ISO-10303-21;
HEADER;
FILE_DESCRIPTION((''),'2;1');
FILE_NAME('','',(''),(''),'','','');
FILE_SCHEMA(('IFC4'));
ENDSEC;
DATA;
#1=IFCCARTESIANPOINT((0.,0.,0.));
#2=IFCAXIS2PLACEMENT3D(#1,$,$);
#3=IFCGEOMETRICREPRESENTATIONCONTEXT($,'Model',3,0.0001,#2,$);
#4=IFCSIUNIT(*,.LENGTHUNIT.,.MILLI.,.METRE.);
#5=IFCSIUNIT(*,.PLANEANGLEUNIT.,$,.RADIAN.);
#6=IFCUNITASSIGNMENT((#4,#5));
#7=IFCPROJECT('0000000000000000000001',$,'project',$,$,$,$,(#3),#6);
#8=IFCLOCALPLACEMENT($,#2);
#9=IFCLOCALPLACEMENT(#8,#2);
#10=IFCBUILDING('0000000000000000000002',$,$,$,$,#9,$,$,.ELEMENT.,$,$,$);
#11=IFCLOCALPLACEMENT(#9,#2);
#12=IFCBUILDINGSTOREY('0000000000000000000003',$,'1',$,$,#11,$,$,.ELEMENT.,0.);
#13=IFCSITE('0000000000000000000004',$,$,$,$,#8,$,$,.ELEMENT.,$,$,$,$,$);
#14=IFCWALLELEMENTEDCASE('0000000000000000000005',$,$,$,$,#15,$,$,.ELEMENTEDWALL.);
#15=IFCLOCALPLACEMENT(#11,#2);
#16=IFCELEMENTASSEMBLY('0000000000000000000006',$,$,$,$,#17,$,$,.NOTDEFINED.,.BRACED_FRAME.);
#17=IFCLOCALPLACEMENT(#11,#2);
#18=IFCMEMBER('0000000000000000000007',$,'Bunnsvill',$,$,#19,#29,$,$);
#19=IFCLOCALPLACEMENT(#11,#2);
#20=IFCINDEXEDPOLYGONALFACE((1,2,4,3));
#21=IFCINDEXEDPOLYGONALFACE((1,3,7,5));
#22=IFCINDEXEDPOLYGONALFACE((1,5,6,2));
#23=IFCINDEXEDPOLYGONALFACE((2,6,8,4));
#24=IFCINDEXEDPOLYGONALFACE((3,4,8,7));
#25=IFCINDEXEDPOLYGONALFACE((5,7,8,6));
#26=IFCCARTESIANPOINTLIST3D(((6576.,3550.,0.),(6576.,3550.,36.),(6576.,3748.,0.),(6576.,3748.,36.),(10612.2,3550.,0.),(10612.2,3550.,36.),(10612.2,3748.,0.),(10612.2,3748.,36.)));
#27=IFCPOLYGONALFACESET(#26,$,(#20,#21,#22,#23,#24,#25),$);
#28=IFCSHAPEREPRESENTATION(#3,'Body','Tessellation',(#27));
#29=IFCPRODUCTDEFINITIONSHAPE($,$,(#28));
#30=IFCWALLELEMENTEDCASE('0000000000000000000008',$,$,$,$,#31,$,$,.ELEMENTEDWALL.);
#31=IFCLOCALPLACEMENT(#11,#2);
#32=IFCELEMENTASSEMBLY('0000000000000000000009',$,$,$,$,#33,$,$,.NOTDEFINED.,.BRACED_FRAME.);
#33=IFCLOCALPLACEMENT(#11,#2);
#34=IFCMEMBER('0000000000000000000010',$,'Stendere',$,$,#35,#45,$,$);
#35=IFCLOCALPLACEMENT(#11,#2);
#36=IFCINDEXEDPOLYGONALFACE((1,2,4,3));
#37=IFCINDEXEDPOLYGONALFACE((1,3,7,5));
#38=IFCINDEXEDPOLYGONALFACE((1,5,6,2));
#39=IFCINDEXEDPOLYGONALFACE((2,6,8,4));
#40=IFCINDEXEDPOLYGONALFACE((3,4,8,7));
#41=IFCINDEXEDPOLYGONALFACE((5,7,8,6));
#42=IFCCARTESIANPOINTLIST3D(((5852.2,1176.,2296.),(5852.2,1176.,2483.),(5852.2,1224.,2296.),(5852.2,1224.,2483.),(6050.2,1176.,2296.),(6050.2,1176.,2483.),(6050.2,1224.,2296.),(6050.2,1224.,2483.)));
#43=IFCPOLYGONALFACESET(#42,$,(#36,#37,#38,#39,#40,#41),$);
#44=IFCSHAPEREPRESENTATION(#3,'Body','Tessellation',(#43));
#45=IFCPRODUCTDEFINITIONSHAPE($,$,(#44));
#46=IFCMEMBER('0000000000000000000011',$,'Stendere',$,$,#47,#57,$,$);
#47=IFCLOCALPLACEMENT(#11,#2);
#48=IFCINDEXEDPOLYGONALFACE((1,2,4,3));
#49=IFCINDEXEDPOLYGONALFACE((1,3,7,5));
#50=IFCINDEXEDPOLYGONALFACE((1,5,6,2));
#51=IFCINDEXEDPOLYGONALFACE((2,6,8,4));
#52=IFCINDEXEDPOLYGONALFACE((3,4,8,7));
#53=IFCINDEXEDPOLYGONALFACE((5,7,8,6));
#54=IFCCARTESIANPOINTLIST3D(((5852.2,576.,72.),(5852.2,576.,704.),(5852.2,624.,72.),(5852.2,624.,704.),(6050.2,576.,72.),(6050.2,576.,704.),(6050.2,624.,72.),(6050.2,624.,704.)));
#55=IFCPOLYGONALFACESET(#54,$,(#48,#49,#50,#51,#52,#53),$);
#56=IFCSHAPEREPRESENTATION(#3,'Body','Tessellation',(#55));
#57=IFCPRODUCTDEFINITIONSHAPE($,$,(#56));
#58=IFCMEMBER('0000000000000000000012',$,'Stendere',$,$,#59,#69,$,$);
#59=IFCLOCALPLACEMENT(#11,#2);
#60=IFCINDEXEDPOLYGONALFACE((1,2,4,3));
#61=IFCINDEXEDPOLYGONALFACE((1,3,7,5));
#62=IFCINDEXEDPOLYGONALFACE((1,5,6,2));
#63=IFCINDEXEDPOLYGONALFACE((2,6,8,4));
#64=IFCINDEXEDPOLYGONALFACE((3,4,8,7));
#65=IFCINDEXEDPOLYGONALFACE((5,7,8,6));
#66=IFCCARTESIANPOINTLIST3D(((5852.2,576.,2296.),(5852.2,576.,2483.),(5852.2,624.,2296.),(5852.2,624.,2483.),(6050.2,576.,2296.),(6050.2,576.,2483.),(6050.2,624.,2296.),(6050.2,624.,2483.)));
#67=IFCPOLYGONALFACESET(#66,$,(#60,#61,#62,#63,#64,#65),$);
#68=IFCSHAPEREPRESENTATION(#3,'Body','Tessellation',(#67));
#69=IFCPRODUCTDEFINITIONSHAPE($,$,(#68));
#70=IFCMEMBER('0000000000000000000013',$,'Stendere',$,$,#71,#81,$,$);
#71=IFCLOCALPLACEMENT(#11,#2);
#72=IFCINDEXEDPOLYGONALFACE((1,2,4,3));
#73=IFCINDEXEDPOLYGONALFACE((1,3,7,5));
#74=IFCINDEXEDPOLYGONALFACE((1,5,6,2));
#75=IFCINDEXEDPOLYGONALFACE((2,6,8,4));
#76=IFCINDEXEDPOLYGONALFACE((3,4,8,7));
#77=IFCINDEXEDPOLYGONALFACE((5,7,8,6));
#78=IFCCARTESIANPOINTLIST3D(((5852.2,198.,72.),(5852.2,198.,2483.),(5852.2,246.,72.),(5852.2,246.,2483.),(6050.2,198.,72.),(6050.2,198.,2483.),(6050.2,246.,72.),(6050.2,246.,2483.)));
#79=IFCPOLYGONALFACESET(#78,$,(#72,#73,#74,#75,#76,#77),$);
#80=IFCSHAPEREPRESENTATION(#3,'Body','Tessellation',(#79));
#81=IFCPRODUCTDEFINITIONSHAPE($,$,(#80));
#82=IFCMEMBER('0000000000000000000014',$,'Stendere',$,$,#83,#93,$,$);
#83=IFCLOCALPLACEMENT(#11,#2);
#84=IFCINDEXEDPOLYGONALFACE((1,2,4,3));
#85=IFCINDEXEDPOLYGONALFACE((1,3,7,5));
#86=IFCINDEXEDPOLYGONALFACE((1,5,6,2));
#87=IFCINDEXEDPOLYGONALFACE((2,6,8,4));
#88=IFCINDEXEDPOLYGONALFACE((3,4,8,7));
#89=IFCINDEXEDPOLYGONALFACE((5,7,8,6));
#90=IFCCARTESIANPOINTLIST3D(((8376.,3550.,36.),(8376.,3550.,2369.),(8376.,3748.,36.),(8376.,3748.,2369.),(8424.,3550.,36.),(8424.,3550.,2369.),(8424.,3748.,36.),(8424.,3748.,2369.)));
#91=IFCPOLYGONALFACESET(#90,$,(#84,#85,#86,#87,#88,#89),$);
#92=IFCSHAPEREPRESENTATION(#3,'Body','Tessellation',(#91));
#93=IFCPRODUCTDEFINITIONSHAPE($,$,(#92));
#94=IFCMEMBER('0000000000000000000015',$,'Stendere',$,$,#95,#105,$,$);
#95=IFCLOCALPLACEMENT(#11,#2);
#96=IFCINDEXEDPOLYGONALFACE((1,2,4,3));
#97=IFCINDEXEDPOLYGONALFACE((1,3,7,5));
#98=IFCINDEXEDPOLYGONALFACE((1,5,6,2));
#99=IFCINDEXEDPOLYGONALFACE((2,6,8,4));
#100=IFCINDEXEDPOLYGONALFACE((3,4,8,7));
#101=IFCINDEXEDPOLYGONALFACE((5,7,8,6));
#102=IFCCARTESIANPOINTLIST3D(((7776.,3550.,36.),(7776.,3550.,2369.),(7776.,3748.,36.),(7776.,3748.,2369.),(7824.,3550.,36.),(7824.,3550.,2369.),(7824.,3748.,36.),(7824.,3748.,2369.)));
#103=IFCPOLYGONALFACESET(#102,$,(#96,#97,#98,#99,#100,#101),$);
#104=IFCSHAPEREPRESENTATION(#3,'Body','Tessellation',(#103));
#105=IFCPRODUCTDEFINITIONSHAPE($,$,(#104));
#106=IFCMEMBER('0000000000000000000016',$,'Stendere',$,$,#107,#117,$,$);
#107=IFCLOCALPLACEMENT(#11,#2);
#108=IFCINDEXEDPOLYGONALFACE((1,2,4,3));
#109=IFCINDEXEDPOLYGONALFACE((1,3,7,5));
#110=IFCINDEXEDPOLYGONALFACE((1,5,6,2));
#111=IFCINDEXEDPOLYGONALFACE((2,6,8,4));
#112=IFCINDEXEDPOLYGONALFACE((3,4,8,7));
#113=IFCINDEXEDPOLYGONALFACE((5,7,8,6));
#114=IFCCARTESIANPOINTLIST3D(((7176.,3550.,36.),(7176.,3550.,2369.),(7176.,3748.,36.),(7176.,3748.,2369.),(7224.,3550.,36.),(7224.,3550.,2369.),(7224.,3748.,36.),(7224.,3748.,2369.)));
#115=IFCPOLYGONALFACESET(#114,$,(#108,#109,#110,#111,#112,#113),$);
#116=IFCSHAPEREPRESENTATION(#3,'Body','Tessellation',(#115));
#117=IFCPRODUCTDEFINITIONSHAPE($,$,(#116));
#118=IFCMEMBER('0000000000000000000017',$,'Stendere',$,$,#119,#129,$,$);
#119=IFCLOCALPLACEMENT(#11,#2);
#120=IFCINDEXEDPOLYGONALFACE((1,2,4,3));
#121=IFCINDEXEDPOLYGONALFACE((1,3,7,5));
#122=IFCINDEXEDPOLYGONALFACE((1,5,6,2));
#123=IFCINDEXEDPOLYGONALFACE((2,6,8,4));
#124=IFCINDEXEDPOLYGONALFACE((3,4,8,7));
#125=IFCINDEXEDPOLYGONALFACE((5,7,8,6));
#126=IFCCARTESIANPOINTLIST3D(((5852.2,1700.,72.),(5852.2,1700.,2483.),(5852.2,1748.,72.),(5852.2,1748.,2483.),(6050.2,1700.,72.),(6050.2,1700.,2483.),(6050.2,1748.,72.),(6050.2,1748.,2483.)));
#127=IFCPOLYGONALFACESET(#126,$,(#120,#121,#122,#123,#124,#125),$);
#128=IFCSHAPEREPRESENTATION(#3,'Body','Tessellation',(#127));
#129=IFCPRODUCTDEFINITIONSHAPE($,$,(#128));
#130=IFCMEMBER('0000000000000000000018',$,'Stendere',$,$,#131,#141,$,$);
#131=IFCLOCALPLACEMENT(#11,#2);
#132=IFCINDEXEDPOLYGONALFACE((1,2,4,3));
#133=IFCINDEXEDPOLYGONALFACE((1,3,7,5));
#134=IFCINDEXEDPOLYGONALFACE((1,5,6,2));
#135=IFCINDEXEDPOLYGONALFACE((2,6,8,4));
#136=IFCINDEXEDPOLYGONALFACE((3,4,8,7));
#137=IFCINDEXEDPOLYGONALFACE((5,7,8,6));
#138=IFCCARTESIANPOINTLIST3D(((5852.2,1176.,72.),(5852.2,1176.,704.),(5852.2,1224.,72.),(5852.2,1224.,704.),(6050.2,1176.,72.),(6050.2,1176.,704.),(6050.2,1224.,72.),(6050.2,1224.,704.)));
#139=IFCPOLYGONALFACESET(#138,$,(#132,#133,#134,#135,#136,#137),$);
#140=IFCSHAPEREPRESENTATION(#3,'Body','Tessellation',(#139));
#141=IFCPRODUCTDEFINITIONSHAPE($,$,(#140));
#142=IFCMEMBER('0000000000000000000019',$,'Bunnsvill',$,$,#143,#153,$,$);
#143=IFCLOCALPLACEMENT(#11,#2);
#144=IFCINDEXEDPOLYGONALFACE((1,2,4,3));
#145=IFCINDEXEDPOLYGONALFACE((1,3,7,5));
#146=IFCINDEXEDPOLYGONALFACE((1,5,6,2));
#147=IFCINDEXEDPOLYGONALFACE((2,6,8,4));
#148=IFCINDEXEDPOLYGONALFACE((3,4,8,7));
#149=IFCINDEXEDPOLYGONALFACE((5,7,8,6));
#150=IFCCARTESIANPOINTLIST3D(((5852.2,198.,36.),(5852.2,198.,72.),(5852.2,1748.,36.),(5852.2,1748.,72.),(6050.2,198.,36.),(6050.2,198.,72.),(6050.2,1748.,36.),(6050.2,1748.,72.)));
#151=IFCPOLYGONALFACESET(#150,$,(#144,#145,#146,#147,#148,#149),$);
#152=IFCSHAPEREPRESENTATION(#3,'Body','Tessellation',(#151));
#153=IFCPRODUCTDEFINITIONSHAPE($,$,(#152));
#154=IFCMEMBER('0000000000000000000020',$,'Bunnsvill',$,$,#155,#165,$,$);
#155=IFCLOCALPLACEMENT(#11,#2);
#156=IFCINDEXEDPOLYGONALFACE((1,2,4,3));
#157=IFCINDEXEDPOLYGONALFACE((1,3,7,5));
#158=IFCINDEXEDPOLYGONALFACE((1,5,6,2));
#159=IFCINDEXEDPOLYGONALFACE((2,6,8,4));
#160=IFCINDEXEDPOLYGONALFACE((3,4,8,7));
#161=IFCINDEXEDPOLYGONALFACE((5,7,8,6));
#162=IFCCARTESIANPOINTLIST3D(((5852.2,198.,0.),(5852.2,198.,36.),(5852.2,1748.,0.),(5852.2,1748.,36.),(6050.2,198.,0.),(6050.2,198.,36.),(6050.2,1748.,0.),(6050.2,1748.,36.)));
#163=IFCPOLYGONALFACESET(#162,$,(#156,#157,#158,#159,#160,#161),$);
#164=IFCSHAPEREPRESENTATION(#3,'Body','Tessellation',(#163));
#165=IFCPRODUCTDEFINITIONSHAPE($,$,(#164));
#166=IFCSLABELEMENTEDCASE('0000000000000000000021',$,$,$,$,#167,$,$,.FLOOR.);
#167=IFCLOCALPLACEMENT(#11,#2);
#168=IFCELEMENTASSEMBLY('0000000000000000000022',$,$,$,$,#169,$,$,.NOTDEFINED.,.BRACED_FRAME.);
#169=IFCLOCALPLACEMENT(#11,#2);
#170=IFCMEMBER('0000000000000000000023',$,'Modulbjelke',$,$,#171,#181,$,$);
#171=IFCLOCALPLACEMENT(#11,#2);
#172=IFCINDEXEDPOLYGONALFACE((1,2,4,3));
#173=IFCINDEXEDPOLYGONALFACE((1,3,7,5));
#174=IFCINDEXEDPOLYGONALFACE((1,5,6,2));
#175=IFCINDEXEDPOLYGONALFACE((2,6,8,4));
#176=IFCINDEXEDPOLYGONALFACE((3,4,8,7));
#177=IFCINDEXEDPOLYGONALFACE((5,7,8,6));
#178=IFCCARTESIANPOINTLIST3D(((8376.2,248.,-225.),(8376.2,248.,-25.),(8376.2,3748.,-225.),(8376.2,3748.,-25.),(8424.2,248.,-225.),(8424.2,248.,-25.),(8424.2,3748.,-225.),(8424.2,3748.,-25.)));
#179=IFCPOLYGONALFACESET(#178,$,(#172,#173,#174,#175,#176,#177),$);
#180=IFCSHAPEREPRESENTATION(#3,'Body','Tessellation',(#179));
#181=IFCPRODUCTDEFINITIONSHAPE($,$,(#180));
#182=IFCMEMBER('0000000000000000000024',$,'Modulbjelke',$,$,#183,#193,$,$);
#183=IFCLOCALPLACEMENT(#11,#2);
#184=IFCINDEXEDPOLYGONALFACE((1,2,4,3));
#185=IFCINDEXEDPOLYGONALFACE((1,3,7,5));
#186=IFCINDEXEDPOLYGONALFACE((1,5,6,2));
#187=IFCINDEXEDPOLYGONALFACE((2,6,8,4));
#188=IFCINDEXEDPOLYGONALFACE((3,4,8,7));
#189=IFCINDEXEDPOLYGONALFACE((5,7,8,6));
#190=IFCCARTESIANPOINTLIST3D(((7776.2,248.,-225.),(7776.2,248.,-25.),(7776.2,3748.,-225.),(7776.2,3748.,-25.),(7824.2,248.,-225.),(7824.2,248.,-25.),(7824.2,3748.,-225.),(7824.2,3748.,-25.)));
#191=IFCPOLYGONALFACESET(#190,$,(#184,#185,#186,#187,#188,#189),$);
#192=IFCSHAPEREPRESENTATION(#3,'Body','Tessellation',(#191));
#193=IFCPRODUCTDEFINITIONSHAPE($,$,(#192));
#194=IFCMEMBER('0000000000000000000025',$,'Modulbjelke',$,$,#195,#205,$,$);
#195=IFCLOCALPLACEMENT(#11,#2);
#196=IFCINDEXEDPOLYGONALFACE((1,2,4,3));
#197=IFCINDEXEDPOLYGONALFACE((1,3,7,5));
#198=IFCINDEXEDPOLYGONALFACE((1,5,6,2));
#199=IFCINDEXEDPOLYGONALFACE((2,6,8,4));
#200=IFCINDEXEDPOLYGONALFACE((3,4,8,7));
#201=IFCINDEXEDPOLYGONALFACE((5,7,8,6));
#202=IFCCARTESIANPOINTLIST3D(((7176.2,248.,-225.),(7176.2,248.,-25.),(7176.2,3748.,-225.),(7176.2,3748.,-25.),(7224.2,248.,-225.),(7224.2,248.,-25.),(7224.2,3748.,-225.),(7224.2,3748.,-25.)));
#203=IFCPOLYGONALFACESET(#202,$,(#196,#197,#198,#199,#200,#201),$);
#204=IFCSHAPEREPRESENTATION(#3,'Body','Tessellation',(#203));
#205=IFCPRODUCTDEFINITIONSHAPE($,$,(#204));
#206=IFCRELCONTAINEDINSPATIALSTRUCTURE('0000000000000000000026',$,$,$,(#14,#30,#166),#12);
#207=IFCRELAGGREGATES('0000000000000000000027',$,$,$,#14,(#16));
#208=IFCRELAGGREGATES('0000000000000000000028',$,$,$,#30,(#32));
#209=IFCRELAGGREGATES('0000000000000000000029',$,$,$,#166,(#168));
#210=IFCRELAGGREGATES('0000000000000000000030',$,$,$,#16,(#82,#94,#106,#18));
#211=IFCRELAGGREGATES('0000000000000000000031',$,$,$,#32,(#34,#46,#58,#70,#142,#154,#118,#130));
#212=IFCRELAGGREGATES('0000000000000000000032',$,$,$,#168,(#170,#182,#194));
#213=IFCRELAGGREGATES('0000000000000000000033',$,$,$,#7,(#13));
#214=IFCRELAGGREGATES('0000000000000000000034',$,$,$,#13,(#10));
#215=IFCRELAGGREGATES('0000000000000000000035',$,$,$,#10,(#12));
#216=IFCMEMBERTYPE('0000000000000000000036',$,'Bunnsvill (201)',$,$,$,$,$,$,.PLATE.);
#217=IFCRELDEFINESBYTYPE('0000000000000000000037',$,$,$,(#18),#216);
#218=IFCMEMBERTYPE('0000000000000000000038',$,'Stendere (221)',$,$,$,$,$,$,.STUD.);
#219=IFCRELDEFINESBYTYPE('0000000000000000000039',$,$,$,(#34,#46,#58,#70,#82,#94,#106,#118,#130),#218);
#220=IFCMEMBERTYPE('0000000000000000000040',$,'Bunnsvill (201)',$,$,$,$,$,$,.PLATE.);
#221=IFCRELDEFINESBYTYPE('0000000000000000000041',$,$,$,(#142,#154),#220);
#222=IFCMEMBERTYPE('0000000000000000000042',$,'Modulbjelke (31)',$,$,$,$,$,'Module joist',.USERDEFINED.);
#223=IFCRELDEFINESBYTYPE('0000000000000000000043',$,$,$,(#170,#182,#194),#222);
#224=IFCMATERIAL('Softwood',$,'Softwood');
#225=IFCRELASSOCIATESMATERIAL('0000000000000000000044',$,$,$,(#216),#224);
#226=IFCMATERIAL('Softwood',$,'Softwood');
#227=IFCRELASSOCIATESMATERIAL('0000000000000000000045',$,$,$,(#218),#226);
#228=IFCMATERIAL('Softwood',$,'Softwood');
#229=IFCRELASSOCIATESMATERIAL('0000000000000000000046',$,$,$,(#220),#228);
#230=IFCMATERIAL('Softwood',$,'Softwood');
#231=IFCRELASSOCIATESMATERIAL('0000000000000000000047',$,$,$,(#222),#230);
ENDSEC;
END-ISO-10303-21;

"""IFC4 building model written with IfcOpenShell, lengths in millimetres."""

from ifc_helpers import new_model, si_unit, frame, origin, place, context, project, spatial, rectangle, extrude, material, material_profile, profile_set, type_object, element, aggregate, save


model = new_model("IFC4")

# Units and contexts
model_context = context("Model", 3, precision=0.0001, world=origin())
ifc_project = project(units=[si_unit("LENGTHUNIT", "METRE", prefix="MILLI"), si_unit("PLANEANGLEUNIT", "RADIAN")], contexts=[model_context])

# Site, building, storey
site_placement = place(None, origin())
site = spatial("IfcSite", under=ifc_project, at=site_placement, CompositionType="ELEMENT")
building_placement = place(site_placement, origin())
building = spatial("IfcBuilding", under=site, at=building_placement, CompositionType="ELEMENT")
storey_placement = place(building_placement, origin())
storey = spatial("IfcBuildingStorey", under=building, at=storey_placement, Name="1", CompositionType="ELEMENT", Elevation=0.0)

# Wall, element assembly, member
wall_1_placement = place(storey_placement, frame((6576.0, 3748.0, 0.0), z_axis=(0.0, -1.0, 0.0)))
wall_1 = element("IfcWallElementedCase", 1, at=wall_1_placement, inside=storey, PredefinedType="ELEMENTEDWALL")
assembly_1_placement = place(wall_1_placement, origin())
assembly_1 = element("IfcElementAssembly", 2, at=assembly_1_placement, AssemblyPlace="NOTDEFINED", PredefinedType="BRACED_FRAME")
aggregate(wall_1, [assembly_1])
ifc_material_1 = material(Name="Softwood", Category="Softwood")
ifc_material_profile_1 = material_profile(ifc_material_1, rectangle(XDim=36.0, YDim=198.0), Name="Bunnsvill (201)")
ifc_profile_set_1 = profile_set([ifc_material_profile_1])
member_type_1 = type_object("IfcMemberType", Name="Bunnsvill (201)", PredefinedType="PLATE", material=ifc_profile_set_1)
member_1_placement = place(assembly_1_placement, frame((0.0, 18.0, 0.0), z_axis=(1.0, 0.0, 0.0), x_axis=(0.0, 1.0, 0.0)))
member_1 = element("IfcMember", 3, at=member_1_placement, type_object=member_type_1, Name="Bunnsvill", context=model_context, shape_type="SweptSolid", body=[
    extrude(rectangle(XDim=36.0, YDim=198.0), frame((0.0, 99.0, 0.0)), (0.0, 0.0, 1.0), 4036.2),
])

# Wall, element assembly, members
wall_2_placement = place(storey_placement, frame((6050.2, 1748.0, 0.0), z_axis=(-1.0, 0.0, 0.0), x_axis=(0.0, -1.0, 0.0)))
wall_2 = element("IfcWallElementedCase", 4, at=wall_2_placement, inside=storey, PredefinedType="ELEMENTEDWALL")
assembly_2_placement = place(wall_2_placement, origin())
assembly_2 = element("IfcElementAssembly", 5, at=assembly_2_placement, AssemblyPlace="NOTDEFINED", PredefinedType="BRACED_FRAME")
aggregate(wall_2, [assembly_2])
ifc_material_2 = material(Name="Softwood", Category="Softwood")
ifc_material_profile_2 = material_profile(ifc_material_2, rectangle(XDim=48.0, YDim=198.0), Name="Stendere (221)")
ifc_profile_set_2 = profile_set([ifc_material_profile_2])
member_type_2 = type_object("IfcMemberType", Name="Stendere (221)", PredefinedType="STUD", material=ifc_profile_set_2)
member_2_placement = place(assembly_2_placement, frame((548.0, 2296.0, 0.0), z_axis=(0.0, 1.0, 0.0), x_axis=(-1.0, 0.0, 0.0)))
member_2 = element("IfcMember", 6, at=member_2_placement, type_object=member_type_2, Name="Stendere", context=model_context, shape_type="SweptSolid", body=[
    extrude(rectangle(XDim=48.0, YDim=198.0), frame((0.0, 99.0, 0.0)), (0.0, 0.0, 1.0), 187.0),
])
member_3_placement = place(assembly_2_placement, frame((1148.0, 72.0, 0.0), z_axis=(0.0, 1.0, 0.0), x_axis=(-1.0, 0.0, 0.0)))
member_3 = element("IfcMember", 7, at=member_3_placement, type_object=member_type_2, Name="Stendere", context=model_context, shape_type="SweptSolid", body=[
    extrude(rectangle(XDim=48.0, YDim=198.0), frame((0.0, 99.0, 0.0)), (0.0, 0.0, 1.0), 632.0),
])
member_4_placement = place(assembly_2_placement, frame((1148.0, 2296.0, 0.0), z_axis=(0.0, 1.0, 0.0), x_axis=(-1.0, 0.0, 0.0)))
member_4 = element("IfcMember", 8, at=member_4_placement, type_object=member_type_2, Name="Stendere", context=model_context, shape_type="SweptSolid", body=[
    extrude(rectangle(XDim=48.0, YDim=198.0), frame((0.0, 99.0, 0.0)), (0.0, 0.0, 1.0), 187.0),
])
member_5_placement = place(assembly_2_placement, frame((1526.0, 72.0, 0.0), z_axis=(0.0, 1.0, 0.0), x_axis=(-1.0, 0.0, 0.0)))
member_5 = element("IfcMember", 9, at=member_5_placement, type_object=member_type_2, Name="Stendere", context=model_context, shape_type="SweptSolid", body=[
    extrude(rectangle(XDim=48.0, YDim=198.0), frame((0.0, 99.0, 0.0)), (0.0, 0.0, 1.0), 2411.0),
])

# Members
member_6_placement = place(assembly_1_placement, frame((1824.0, 36.0, 0.0), z_axis=(0.0, 1.0, 0.0), x_axis=(-1.0, 0.0, 0.0)))
member_6 = element("IfcMember", 10, at=member_6_placement, type_object=member_type_2, Name="Stendere", context=model_context, shape_type="SweptSolid", body=[
    extrude(rectangle(XDim=48.0, YDim=198.0), frame((0.0, 99.0, 0.0)), (0.0, 0.0, 1.0), 2333.0),
])
member_7_placement = place(assembly_1_placement, frame((1224.0, 36.0, 0.0), z_axis=(0.0, 1.0, 0.0), x_axis=(-1.0, 0.0, 0.0)))
member_7 = element("IfcMember", 11, at=member_7_placement, type_object=member_type_2, Name="Stendere", context=model_context, shape_type="SweptSolid", body=[
    extrude(rectangle(XDim=48.0, YDim=198.0), frame((0.0, 99.0, 0.0)), (0.0, 0.0, 1.0), 2333.0),
])
member_8_placement = place(assembly_1_placement, frame((624.0, 36.0, 0.0), z_axis=(0.0, 1.0, 0.0), x_axis=(-1.0, 0.0, 0.0)))
member_8 = element("IfcMember", 12, at=member_8_placement, type_object=member_type_2, Name="Stendere", context=model_context, shape_type="SweptSolid", body=[
    extrude(rectangle(XDim=48.0, YDim=198.0), frame((0.0, 99.0, 0.0)), (0.0, 0.0, 1.0), 2333.0),
])
member_9_placement = place(assembly_2_placement, frame((24.0, 72.0, 0.0), z_axis=(0.0, 1.0, 0.0), x_axis=(-1.0, 0.0, 0.0)))
member_9 = element("IfcMember", 13, at=member_9_placement, type_object=member_type_2, Name="Stendere", context=model_context, shape_type="SweptSolid", body=[
    extrude(rectangle(XDim=48.0, YDim=198.0), frame((0.0, 99.0, 0.0)), (0.0, 0.0, 1.0), 2411.0),
])
member_10_placement = place(assembly_2_placement, frame((548.0, 72.0, 0.0), z_axis=(0.0, 1.0, 0.0), x_axis=(-1.0, 0.0, 0.0)))
member_10 = element("IfcMember", 14, at=member_10_placement, type_object=member_type_2, Name="Stendere", context=model_context, shape_type="SweptSolid", body=[
    extrude(rectangle(XDim=48.0, YDim=198.0), frame((0.0, 99.0, 0.0)), (0.0, 0.0, 1.0), 632.0),
])
ifc_material_3 = material(Name="Softwood", Category="Softwood")
ifc_material_profile_3 = material_profile(ifc_material_3, rectangle(XDim=36.0, YDim=198.0), Name="Bunnsvill (201)")
ifc_profile_set_3 = profile_set([ifc_material_profile_3])
member_type_3 = type_object("IfcMemberType", Name="Bunnsvill (201)", PredefinedType="PLATE", material=ifc_profile_set_3)
member_11_placement = place(assembly_2_placement, frame((0.0, 54.0, 0.0), z_axis=(1.0, 0.0, 0.0), x_axis=(0.0, 1.0, 0.0)))
member_11 = element("IfcMember", 15, at=member_11_placement, type_object=member_type_3, Name="Bunnsvill", context=model_context, shape_type="SweptSolid", body=[
    extrude(rectangle(XDim=36.0, YDim=198.0), frame((0.0, 99.0, 0.0)), (0.0, 0.0, 1.0), 1550.0),
])
member_12_placement = place(assembly_2_placement, frame((0.0, 18.0, 0.0), z_axis=(1.0, 0.0, 0.0), x_axis=(0.0, 1.0, 0.0)))
member_12 = element("IfcMember", 16, at=member_12_placement, type_object=member_type_3, Name="Bunnsvill", context=model_context, shape_type="SweptSolid", body=[
    extrude(rectangle(XDim=36.0, YDim=198.0), frame((0.0, 99.0, 0.0)), (0.0, 0.0, 1.0), 1550.0),
])

# Slab, element assembly, members
slab_placement = place(storey_placement, origin())
slab = element("IfcSlabElementedCase", 17, at=slab_placement, inside=storey, PredefinedType="FLOOR")
assembly_3_placement = place(slab_placement, frame((0.0, 0.0, -225.0)))
assembly_3 = element("IfcElementAssembly", 18, at=assembly_3_placement, AssemblyPlace="NOTDEFINED", PredefinedType="BRACED_FRAME")
aggregate(slab, [assembly_3])
ifc_material_4 = material(Name="Softwood", Category="Softwood")
ifc_material_profile_4 = material_profile(ifc_material_4, rectangle(XDim=48.0, YDim=200.0), Name="Modulbjelke (31)")
ifc_profile_set_4 = profile_set([ifc_material_profile_4])
member_type_4 = type_object("IfcMemberType", Name="Modulbjelke (31)", ElementType="Module joist", PredefinedType="USERDEFINED", material=ifc_profile_set_4)
member_13_placement = place(assembly_3_placement, frame((8400.2, 248.0, 0.0), z_axis=(0.0, 1.0, 0.0), x_axis=(-1.0, 0.0, 0.0)))
member_13 = element("IfcMember", 19, at=member_13_placement, type_object=member_type_4, Name="Modulbjelke", context=model_context, shape_type="SweptSolid", body=[
    extrude(rectangle(XDim=48.0, YDim=200.0), frame((0.0, 100.0, 0.0)), (0.0, 0.0, 1.0), 3500.0),
])
member_14_placement = place(assembly_3_placement, frame((7800.2, 248.0, 0.0), z_axis=(0.0, 1.0, 0.0), x_axis=(-1.0, 0.0, 0.0)))
member_14 = element("IfcMember", 20, at=member_14_placement, type_object=member_type_4, Name="Modulbjelke", context=model_context, shape_type="SweptSolid", body=[
    extrude(rectangle(XDim=48.0, YDim=200.0), frame((0.0, 100.0, 0.0)), (0.0, 0.0, 1.0), 3500.0),
])
member_15_placement = place(assembly_3_placement, frame((7200.2, 248.0, 0.0), z_axis=(0.0, 1.0, 0.0), x_axis=(-1.0, 0.0, 0.0)))
member_15 = element("IfcMember", 21, at=member_15_placement, type_object=member_type_4, Name="Modulbjelke", context=model_context, shape_type="SweptSolid", body=[
    extrude(rectangle(XDim=48.0, YDim=200.0), frame((0.0, 100.0, 0.0)), (0.0, 0.0, 1.0), 3500.0),
])

aggregate(assembly_1, [member_6, member_7, member_8, member_1])
aggregate(assembly_2, [member_2, member_3, member_4, member_5, member_11, member_12, member_9, member_10])
aggregate(assembly_3, [member_13, member_14, member_15])

save(model, "model.ifc")
